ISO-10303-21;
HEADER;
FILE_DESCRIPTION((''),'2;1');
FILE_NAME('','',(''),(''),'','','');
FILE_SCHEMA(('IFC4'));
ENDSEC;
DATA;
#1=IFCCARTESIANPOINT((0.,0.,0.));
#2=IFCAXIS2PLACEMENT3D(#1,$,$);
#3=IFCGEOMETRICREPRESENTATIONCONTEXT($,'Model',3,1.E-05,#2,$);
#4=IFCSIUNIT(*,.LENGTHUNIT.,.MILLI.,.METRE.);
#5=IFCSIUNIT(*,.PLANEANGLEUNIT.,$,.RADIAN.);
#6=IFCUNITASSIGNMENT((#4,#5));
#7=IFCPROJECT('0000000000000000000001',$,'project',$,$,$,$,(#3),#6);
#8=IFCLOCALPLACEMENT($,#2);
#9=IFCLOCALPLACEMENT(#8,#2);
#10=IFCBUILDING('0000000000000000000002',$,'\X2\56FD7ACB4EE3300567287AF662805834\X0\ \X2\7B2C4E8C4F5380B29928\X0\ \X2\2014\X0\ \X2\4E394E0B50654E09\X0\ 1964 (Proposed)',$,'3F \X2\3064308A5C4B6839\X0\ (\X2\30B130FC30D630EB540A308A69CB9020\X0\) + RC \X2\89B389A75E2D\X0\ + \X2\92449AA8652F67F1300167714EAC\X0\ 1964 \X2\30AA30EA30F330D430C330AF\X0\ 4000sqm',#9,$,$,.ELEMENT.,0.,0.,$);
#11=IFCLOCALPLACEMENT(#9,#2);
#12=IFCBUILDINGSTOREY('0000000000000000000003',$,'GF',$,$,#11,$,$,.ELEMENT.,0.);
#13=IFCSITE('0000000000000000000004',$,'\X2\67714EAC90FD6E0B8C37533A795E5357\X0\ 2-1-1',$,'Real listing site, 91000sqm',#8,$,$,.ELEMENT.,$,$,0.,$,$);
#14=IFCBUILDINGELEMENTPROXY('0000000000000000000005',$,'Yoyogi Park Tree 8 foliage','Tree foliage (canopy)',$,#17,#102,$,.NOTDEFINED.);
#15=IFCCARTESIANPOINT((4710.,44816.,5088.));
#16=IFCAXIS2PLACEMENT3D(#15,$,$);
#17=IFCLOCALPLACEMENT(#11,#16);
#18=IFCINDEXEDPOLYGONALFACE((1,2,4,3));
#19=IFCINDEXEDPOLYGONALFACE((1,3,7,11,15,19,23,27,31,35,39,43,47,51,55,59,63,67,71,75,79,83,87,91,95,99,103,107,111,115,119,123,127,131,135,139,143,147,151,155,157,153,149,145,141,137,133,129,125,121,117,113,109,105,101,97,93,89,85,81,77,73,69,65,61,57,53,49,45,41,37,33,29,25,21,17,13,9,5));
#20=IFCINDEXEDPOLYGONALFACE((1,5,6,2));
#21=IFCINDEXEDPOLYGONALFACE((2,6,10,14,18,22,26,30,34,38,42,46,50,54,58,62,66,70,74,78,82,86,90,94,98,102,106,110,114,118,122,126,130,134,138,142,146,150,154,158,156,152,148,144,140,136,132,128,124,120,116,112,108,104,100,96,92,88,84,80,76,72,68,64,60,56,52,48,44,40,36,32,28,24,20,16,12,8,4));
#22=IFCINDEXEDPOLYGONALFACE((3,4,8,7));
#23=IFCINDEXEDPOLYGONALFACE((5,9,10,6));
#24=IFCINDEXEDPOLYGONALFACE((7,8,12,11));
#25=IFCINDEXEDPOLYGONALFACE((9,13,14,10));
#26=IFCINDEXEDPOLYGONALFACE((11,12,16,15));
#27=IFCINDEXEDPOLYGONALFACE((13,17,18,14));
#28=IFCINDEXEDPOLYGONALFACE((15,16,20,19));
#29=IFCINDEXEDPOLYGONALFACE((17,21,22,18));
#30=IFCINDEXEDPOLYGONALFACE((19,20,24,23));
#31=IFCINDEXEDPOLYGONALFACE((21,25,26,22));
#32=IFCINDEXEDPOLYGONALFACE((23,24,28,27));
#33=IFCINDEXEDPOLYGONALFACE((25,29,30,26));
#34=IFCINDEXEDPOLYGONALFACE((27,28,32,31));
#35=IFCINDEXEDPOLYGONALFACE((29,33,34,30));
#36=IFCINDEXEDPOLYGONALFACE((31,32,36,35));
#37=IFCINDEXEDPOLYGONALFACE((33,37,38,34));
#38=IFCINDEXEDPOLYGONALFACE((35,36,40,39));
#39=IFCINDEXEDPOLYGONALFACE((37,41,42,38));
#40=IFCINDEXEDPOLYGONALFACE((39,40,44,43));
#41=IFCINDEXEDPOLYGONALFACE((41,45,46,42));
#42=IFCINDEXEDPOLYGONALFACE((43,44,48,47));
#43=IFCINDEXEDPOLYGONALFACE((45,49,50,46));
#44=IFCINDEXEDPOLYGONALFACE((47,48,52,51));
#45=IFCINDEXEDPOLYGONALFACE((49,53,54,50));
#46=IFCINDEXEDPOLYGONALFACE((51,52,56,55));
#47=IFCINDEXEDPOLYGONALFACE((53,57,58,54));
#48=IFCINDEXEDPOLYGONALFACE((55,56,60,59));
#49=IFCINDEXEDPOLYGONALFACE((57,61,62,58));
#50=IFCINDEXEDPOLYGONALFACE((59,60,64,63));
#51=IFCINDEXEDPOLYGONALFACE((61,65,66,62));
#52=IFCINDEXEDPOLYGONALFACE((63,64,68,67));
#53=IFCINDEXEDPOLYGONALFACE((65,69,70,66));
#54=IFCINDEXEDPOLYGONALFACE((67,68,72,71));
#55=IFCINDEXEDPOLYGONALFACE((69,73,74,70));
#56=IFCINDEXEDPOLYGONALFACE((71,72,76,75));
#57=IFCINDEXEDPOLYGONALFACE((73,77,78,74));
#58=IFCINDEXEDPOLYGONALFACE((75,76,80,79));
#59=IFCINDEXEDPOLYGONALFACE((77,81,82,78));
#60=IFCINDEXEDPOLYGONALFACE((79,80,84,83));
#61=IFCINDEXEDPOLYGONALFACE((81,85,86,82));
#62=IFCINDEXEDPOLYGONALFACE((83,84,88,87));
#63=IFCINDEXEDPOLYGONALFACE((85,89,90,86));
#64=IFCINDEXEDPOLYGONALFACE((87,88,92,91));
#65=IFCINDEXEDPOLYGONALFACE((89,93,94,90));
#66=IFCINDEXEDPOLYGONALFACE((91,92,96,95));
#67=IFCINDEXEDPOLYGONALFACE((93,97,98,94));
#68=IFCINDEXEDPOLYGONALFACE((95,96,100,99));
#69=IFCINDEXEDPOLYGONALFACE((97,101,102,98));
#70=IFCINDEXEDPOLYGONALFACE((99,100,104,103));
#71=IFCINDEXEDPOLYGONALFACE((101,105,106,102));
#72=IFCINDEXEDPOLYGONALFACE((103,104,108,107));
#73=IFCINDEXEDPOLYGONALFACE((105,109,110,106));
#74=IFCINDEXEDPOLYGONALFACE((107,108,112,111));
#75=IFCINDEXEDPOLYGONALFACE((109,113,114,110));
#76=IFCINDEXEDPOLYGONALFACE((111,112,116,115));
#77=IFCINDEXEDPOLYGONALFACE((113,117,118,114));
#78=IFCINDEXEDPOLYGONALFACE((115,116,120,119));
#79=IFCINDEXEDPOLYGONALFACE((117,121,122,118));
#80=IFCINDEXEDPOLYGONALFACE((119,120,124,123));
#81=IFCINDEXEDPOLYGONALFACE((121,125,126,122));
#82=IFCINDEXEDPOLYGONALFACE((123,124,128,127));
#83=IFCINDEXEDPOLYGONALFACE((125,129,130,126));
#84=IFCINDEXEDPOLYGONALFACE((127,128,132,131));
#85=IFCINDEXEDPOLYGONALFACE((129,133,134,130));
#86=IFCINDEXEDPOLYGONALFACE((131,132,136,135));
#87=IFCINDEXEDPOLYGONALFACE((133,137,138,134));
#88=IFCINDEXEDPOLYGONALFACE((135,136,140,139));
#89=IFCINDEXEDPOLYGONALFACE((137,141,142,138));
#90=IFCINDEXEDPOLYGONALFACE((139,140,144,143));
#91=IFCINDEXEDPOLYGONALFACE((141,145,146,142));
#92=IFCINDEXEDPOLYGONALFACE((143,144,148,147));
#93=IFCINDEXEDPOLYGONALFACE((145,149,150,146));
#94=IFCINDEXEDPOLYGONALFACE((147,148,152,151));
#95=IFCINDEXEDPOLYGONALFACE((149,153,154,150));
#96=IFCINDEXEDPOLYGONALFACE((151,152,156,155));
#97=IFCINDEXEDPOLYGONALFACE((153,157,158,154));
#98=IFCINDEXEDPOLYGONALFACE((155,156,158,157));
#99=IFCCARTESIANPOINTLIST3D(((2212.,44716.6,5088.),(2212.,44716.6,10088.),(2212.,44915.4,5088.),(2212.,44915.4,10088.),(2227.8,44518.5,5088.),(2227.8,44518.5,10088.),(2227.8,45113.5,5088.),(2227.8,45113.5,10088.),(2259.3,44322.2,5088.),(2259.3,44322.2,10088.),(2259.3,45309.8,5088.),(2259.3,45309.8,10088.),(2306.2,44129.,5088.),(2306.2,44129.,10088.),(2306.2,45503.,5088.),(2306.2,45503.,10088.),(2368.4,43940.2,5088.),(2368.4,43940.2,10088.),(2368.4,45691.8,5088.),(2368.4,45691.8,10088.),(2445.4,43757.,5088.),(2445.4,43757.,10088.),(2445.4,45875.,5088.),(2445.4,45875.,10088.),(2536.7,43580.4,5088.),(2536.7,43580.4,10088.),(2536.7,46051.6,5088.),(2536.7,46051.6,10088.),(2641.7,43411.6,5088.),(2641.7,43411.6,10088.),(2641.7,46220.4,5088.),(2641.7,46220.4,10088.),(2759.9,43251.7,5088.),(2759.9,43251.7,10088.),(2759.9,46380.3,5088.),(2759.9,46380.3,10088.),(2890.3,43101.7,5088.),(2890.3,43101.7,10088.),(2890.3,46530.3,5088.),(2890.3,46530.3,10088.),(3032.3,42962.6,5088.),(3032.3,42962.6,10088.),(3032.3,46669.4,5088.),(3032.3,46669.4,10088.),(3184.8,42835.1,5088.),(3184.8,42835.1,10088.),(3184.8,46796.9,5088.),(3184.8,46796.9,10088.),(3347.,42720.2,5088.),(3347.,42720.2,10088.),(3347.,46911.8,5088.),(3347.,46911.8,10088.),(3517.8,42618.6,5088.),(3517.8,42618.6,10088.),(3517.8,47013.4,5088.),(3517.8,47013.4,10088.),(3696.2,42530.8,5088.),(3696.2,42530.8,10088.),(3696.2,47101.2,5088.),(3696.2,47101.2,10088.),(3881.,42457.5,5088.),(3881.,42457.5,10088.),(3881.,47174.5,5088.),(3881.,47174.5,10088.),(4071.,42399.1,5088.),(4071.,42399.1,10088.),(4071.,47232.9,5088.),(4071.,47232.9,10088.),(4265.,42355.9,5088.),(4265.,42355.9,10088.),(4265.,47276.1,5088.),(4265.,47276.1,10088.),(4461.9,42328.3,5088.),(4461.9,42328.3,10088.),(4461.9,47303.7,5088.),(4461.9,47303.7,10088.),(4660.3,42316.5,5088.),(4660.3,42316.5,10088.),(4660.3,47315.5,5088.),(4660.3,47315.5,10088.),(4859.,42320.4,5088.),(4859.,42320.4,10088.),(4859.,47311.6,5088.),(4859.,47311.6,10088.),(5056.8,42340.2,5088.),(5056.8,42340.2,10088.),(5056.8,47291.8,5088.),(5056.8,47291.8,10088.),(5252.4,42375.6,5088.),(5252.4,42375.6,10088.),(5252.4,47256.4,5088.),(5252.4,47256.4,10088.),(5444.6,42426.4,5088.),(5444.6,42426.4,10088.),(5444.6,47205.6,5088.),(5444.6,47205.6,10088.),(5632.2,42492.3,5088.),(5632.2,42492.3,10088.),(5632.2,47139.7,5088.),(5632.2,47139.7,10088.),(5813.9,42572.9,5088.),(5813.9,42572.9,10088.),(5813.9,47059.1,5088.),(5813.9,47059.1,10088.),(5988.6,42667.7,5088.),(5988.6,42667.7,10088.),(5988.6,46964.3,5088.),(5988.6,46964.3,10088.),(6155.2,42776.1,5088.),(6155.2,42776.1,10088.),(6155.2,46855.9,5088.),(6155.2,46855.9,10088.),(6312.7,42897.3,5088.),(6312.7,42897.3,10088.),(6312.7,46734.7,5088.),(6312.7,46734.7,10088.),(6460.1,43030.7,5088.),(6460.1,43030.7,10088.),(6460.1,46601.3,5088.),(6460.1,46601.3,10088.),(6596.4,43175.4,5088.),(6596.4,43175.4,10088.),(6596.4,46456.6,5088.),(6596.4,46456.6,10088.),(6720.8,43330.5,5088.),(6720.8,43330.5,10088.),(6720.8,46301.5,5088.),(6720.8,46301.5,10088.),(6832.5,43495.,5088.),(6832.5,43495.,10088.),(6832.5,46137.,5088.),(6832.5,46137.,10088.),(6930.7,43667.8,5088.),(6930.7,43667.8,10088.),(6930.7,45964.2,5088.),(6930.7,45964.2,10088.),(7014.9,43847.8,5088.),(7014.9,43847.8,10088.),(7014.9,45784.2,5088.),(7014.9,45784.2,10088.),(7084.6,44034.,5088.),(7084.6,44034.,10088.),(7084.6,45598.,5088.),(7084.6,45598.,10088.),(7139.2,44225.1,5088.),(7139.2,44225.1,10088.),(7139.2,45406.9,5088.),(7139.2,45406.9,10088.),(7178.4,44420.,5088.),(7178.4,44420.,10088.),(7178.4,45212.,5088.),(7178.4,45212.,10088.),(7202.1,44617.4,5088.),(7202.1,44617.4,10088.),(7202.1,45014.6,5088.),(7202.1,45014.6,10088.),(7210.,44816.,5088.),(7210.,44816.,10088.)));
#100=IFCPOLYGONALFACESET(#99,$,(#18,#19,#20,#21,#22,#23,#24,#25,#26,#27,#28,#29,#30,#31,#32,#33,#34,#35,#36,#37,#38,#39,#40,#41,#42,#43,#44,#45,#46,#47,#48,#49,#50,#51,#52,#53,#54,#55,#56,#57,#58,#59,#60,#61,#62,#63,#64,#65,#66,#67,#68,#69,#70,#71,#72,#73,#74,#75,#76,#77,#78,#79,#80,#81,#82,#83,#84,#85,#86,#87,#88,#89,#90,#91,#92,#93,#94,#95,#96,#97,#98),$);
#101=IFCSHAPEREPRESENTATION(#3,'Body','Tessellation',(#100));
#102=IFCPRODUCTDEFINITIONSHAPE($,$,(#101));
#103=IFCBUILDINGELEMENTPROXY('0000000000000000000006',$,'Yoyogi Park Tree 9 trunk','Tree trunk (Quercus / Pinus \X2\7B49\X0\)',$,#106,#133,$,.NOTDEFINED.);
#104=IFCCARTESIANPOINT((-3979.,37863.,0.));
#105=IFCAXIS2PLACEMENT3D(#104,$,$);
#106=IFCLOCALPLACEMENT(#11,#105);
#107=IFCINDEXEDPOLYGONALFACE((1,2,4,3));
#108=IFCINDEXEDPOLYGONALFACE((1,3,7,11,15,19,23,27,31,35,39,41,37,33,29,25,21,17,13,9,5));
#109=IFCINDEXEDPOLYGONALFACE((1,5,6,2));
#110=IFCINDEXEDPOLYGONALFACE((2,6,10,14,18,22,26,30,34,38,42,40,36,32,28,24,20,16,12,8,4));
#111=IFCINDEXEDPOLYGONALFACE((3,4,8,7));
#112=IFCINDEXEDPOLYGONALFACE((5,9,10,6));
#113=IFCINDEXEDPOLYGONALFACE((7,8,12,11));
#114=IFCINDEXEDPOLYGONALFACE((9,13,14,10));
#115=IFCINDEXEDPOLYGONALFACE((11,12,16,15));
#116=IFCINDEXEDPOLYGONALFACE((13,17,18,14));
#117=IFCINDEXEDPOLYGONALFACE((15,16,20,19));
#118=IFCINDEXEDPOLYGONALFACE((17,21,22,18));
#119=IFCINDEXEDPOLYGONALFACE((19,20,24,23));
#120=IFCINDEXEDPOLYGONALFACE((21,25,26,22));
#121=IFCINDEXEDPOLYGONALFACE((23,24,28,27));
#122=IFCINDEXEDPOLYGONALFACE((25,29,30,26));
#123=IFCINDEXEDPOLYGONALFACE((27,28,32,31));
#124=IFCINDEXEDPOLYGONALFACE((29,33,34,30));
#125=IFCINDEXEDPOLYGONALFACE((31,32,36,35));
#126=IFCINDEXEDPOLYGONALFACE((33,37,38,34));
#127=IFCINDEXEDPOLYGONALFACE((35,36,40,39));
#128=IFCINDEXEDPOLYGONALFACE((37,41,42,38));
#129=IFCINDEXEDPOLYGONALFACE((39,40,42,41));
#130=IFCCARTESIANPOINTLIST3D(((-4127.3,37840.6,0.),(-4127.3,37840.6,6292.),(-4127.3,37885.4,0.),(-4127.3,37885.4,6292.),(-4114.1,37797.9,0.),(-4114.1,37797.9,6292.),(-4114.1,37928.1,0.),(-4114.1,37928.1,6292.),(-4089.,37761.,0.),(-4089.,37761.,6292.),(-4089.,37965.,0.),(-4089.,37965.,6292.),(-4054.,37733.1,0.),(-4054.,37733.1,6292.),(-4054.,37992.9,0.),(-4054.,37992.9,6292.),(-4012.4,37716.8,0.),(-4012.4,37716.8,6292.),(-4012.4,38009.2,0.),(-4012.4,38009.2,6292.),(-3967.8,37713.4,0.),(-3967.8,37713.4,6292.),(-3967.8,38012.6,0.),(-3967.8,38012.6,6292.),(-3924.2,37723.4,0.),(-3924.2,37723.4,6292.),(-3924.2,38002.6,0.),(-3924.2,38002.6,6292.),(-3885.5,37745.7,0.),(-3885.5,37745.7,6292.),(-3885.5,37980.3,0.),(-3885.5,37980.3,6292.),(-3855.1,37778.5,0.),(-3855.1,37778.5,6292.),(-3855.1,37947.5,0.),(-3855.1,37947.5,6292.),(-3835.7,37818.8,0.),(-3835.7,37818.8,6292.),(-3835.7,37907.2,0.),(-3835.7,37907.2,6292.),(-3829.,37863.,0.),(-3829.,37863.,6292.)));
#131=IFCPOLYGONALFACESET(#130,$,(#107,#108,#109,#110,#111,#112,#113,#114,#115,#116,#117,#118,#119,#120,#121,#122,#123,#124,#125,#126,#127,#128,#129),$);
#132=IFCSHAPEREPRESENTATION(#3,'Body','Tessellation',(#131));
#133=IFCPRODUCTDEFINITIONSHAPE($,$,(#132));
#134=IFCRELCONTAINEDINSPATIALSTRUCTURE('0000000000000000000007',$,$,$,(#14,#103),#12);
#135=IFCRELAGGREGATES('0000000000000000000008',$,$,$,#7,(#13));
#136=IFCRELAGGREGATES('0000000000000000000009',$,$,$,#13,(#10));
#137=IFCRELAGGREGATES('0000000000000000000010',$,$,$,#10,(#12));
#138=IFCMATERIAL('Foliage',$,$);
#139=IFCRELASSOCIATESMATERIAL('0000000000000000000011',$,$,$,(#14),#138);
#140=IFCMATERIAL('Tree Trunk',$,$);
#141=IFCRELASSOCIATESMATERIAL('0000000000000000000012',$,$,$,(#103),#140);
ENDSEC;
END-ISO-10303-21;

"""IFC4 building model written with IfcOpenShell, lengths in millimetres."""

from ifc_helpers import new_model, si_unit, frame, origin, origin_2d, place, context, project, spatial, circle, extrude, material, element, save


model = new_model("IFC4")

# Units and contexts
model_context = context("Model", 3, precision=1e-05, world=origin())
ifc_project = project(units=[si_unit("LENGTHUNIT", "METRE", prefix="MILLI"), si_unit("PLANEANGLEUNIT", "RADIAN")], contexts=[model_context])

# Site, building, storey
site_placement = place(None, origin())
site = spatial("IfcSite", under=ifc_project, at=site_placement, Name="東京都渋谷区神南 2-1-1", ObjectType="Real listing site, 91000sqm", CompositionType="ELEMENT", RefElevation=0.0)
building_placement = place(site_placement, origin())
building = spatial("IfcBuilding", under=site, at=building_placement, Name="国立代々木競技場 第二体育館 — 丹下健三 1964 (Proposed)", ObjectType="3F つり屋根 (ケーブル吊り構造) + RC 観覧席 + 鉄骨支柱、東京 1964 オリンピック 4000sqm", CompositionType="ELEMENT", ElevationOfRefHeight=0.0, ElevationOfTerrain=0.0)
storey_placement = place(building_placement, origin())
storey = spatial("IfcBuildingStorey", under=building, at=storey_placement, Name="GF", CompositionType="ELEMENT", Elevation=0.0)

# Building element proxies
ifc_material_1 = material(Name="Tree Trunk")
ifc_material_2 = material(Name="Foliage")
proxy_1_placement = place(storey_placement, frame((4710.0, 44816.0, 5088.0)))
element("IfcBuildingElementProxy", 1, at=proxy_1_placement, inside=storey, material=ifc_material_2, Name="Yoyogi Park Tree 8 foliage", Description="Tree foliage (canopy)", PredefinedType="NOTDEFINED", context=model_context, shape_type="SweptSolid", body=[
    extrude(circle(Radius=2500.0, at=origin_2d()), frame((4710.0, 44816.0, 5088.0)), (0.0, 0.0, 1.0), 5000.0),
])
proxy_2_placement = place(storey_placement, frame((-3979.0, 37863.0, 0.0)))
element("IfcBuildingElementProxy", 2, at=proxy_2_placement, inside=storey, material=ifc_material_1, Name="Yoyogi Park Tree 9 trunk", Description="Tree trunk (Quercus / Pinus 等)", PredefinedType="NOTDEFINED", context=model_context, shape_type="SweptSolid", body=[
    extrude(circle(Radius=150.0, at=origin_2d()), frame((-3979.0, 37863.0, 0.0)), (0.0, 0.0, 1.0), 6292.0),
])

save(model, "model.ifc")
